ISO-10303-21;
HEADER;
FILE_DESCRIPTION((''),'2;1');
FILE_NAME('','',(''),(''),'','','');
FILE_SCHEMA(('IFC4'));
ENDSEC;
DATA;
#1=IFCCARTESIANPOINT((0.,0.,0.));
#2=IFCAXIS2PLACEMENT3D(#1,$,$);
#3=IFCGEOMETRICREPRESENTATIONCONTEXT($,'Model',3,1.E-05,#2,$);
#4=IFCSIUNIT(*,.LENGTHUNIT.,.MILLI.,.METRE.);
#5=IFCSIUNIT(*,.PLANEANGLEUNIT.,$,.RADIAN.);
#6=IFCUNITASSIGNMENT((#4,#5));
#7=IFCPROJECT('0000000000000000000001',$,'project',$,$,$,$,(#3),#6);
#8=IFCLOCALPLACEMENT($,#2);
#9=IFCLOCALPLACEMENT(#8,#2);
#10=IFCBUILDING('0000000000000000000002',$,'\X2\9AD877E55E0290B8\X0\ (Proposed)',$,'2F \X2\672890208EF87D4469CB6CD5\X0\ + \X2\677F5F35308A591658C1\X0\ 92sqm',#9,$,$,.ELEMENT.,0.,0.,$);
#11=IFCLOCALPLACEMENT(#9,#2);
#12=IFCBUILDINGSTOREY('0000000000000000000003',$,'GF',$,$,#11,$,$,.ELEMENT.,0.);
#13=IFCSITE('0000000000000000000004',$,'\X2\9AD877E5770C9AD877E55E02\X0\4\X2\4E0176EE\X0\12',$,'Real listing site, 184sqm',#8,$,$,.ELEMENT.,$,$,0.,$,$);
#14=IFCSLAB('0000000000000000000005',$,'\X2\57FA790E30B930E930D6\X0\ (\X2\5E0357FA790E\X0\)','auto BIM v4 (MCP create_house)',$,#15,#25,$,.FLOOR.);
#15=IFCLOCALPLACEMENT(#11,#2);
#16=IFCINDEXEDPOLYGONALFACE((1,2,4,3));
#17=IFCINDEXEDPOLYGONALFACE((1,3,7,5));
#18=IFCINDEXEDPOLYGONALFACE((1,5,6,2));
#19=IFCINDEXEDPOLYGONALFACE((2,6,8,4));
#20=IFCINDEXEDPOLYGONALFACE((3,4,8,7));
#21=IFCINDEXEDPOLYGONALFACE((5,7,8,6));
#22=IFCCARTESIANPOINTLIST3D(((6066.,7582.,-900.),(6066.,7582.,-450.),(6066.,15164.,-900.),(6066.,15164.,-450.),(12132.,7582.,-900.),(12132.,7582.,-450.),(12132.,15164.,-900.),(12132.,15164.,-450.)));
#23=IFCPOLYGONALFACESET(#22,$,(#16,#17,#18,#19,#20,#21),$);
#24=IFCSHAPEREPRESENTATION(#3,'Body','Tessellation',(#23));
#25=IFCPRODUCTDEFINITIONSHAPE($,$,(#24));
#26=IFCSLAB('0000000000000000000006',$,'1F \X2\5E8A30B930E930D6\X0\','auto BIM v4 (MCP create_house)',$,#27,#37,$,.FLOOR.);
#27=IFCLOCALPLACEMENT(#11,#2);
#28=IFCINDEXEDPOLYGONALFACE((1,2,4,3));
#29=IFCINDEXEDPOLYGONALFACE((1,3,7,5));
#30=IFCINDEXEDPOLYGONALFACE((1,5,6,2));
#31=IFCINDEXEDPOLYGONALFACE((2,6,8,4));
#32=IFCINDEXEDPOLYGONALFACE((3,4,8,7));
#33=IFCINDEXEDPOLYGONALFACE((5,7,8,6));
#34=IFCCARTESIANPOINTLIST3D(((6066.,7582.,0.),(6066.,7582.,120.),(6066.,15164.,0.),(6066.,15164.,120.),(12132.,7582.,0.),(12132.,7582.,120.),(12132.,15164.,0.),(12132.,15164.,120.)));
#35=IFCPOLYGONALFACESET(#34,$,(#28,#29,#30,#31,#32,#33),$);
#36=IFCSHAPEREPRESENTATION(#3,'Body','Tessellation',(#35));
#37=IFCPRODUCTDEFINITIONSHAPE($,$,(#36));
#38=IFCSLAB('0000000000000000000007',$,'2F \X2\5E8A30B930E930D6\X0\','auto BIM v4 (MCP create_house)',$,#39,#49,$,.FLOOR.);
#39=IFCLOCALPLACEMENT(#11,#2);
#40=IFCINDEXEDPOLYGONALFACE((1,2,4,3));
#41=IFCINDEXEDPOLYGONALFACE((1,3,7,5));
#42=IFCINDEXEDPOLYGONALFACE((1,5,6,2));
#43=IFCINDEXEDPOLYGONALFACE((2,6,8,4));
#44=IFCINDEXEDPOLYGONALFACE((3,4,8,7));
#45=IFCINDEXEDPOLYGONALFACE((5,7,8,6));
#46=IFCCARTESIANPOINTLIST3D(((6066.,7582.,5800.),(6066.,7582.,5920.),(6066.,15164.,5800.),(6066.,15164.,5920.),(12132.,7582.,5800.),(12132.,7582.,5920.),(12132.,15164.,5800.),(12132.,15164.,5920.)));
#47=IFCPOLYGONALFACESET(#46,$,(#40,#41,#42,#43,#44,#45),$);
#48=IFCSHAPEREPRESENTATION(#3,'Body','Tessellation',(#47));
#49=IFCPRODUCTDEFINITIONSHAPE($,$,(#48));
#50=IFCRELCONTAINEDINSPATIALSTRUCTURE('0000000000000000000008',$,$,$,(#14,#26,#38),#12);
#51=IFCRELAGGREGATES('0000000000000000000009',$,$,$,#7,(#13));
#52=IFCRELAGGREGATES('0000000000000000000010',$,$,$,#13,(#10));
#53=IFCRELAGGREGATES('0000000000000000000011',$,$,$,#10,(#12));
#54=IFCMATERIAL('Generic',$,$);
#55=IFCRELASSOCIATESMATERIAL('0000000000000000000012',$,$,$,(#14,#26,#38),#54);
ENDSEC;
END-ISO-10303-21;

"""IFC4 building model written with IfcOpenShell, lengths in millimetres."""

from ifc_helpers import new_model, si_unit, frame, frame_2d, origin, place, context, project, spatial, rectangle, extrude, material, element, save


model = new_model("IFC4")

# Units and contexts
model_context = context("Model", 3, precision=1e-05, world=origin())
ifc_project = project(units=[si_unit("LENGTHUNIT", "METRE", prefix="MILLI"), si_unit("PLANEANGLEUNIT", "RADIAN")], contexts=[model_context])

# Site, building, storey
site_placement = place(None, origin())
site = spatial("IfcSite", under=ifc_project, at=site_placement, Name="高知県高知市4丁目12", ObjectType="Real listing site, 184sqm", CompositionType="ELEMENT", RefElevation=0.0)
building_placement = place(site_placement, origin())
building = spatial("IfcBuilding", under=site, at=building_placement, Name="高知市邸 (Proposed)", ObjectType="2F 木造軸組構法 + 板張り外壁 92sqm", CompositionType="ELEMENT", ElevationOfRefHeight=0.0, ElevationOfTerrain=0.0)
storey_placement = place(building_placement, origin())
storey = spatial("IfcBuildingStorey", under=building, at=storey_placement, Name="GF", CompositionType="ELEMENT", Elevation=0.0)

# Slabs
ifc_material = material(Name="Generic")
slab_1_placement = place(storey_placement, frame((3033.0, 3791.0, -450.0)))
element("IfcSlab", 1, at=slab_1_placement, inside=storey, material=ifc_material, Name="基礎スラブ (布基礎)", Description="auto BIM v4 (MCP create_house)", PredefinedType="FLOOR", context=model_context, shape_type="SweptSolid", body=[
    extrude(rectangle(XDim=6066.0, YDim=7582.0, at=frame_2d((3033.0, 3791.0))), frame((3033.0, 3791.0, -450.0)), (0.0, 0.0, 1.0), 450.0),
])
slab_2_placement = place(storey_placement, frame((3033.0, 3791.0, 0.0)))
element("IfcSlab", 2, at=slab_2_placement, inside=storey, material=ifc_material, Name="1F 床スラブ", Description="auto BIM v4 (MCP create_house)", PredefinedType="FLOOR", context=model_context, shape_type="SweptSolid", body=[
    extrude(rectangle(XDim=6066.0, YDim=7582.0, at=frame_2d((3033.0, 3791.0))), frame((3033.0, 3791.0, 0.0)), (0.0, 0.0, 1.0), 120.0),
])
slab_3_placement = place(storey_placement, frame((3033.0, 3791.0, 2900.0)))
element("IfcSlab", 3, at=slab_3_placement, inside=storey, material=ifc_material, Name="2F 床スラブ", Description="auto BIM v4 (MCP create_house)", PredefinedType="FLOOR", context=model_context, shape_type="SweptSolid", body=[
    extrude(rectangle(XDim=6066.0, YDim=7582.0, at=frame_2d((3033.0, 3791.0))), frame((3033.0, 3791.0, 2900.0)), (0.0, 0.0, 1.0), 120.0),
])

save(model, "model.ifc")
